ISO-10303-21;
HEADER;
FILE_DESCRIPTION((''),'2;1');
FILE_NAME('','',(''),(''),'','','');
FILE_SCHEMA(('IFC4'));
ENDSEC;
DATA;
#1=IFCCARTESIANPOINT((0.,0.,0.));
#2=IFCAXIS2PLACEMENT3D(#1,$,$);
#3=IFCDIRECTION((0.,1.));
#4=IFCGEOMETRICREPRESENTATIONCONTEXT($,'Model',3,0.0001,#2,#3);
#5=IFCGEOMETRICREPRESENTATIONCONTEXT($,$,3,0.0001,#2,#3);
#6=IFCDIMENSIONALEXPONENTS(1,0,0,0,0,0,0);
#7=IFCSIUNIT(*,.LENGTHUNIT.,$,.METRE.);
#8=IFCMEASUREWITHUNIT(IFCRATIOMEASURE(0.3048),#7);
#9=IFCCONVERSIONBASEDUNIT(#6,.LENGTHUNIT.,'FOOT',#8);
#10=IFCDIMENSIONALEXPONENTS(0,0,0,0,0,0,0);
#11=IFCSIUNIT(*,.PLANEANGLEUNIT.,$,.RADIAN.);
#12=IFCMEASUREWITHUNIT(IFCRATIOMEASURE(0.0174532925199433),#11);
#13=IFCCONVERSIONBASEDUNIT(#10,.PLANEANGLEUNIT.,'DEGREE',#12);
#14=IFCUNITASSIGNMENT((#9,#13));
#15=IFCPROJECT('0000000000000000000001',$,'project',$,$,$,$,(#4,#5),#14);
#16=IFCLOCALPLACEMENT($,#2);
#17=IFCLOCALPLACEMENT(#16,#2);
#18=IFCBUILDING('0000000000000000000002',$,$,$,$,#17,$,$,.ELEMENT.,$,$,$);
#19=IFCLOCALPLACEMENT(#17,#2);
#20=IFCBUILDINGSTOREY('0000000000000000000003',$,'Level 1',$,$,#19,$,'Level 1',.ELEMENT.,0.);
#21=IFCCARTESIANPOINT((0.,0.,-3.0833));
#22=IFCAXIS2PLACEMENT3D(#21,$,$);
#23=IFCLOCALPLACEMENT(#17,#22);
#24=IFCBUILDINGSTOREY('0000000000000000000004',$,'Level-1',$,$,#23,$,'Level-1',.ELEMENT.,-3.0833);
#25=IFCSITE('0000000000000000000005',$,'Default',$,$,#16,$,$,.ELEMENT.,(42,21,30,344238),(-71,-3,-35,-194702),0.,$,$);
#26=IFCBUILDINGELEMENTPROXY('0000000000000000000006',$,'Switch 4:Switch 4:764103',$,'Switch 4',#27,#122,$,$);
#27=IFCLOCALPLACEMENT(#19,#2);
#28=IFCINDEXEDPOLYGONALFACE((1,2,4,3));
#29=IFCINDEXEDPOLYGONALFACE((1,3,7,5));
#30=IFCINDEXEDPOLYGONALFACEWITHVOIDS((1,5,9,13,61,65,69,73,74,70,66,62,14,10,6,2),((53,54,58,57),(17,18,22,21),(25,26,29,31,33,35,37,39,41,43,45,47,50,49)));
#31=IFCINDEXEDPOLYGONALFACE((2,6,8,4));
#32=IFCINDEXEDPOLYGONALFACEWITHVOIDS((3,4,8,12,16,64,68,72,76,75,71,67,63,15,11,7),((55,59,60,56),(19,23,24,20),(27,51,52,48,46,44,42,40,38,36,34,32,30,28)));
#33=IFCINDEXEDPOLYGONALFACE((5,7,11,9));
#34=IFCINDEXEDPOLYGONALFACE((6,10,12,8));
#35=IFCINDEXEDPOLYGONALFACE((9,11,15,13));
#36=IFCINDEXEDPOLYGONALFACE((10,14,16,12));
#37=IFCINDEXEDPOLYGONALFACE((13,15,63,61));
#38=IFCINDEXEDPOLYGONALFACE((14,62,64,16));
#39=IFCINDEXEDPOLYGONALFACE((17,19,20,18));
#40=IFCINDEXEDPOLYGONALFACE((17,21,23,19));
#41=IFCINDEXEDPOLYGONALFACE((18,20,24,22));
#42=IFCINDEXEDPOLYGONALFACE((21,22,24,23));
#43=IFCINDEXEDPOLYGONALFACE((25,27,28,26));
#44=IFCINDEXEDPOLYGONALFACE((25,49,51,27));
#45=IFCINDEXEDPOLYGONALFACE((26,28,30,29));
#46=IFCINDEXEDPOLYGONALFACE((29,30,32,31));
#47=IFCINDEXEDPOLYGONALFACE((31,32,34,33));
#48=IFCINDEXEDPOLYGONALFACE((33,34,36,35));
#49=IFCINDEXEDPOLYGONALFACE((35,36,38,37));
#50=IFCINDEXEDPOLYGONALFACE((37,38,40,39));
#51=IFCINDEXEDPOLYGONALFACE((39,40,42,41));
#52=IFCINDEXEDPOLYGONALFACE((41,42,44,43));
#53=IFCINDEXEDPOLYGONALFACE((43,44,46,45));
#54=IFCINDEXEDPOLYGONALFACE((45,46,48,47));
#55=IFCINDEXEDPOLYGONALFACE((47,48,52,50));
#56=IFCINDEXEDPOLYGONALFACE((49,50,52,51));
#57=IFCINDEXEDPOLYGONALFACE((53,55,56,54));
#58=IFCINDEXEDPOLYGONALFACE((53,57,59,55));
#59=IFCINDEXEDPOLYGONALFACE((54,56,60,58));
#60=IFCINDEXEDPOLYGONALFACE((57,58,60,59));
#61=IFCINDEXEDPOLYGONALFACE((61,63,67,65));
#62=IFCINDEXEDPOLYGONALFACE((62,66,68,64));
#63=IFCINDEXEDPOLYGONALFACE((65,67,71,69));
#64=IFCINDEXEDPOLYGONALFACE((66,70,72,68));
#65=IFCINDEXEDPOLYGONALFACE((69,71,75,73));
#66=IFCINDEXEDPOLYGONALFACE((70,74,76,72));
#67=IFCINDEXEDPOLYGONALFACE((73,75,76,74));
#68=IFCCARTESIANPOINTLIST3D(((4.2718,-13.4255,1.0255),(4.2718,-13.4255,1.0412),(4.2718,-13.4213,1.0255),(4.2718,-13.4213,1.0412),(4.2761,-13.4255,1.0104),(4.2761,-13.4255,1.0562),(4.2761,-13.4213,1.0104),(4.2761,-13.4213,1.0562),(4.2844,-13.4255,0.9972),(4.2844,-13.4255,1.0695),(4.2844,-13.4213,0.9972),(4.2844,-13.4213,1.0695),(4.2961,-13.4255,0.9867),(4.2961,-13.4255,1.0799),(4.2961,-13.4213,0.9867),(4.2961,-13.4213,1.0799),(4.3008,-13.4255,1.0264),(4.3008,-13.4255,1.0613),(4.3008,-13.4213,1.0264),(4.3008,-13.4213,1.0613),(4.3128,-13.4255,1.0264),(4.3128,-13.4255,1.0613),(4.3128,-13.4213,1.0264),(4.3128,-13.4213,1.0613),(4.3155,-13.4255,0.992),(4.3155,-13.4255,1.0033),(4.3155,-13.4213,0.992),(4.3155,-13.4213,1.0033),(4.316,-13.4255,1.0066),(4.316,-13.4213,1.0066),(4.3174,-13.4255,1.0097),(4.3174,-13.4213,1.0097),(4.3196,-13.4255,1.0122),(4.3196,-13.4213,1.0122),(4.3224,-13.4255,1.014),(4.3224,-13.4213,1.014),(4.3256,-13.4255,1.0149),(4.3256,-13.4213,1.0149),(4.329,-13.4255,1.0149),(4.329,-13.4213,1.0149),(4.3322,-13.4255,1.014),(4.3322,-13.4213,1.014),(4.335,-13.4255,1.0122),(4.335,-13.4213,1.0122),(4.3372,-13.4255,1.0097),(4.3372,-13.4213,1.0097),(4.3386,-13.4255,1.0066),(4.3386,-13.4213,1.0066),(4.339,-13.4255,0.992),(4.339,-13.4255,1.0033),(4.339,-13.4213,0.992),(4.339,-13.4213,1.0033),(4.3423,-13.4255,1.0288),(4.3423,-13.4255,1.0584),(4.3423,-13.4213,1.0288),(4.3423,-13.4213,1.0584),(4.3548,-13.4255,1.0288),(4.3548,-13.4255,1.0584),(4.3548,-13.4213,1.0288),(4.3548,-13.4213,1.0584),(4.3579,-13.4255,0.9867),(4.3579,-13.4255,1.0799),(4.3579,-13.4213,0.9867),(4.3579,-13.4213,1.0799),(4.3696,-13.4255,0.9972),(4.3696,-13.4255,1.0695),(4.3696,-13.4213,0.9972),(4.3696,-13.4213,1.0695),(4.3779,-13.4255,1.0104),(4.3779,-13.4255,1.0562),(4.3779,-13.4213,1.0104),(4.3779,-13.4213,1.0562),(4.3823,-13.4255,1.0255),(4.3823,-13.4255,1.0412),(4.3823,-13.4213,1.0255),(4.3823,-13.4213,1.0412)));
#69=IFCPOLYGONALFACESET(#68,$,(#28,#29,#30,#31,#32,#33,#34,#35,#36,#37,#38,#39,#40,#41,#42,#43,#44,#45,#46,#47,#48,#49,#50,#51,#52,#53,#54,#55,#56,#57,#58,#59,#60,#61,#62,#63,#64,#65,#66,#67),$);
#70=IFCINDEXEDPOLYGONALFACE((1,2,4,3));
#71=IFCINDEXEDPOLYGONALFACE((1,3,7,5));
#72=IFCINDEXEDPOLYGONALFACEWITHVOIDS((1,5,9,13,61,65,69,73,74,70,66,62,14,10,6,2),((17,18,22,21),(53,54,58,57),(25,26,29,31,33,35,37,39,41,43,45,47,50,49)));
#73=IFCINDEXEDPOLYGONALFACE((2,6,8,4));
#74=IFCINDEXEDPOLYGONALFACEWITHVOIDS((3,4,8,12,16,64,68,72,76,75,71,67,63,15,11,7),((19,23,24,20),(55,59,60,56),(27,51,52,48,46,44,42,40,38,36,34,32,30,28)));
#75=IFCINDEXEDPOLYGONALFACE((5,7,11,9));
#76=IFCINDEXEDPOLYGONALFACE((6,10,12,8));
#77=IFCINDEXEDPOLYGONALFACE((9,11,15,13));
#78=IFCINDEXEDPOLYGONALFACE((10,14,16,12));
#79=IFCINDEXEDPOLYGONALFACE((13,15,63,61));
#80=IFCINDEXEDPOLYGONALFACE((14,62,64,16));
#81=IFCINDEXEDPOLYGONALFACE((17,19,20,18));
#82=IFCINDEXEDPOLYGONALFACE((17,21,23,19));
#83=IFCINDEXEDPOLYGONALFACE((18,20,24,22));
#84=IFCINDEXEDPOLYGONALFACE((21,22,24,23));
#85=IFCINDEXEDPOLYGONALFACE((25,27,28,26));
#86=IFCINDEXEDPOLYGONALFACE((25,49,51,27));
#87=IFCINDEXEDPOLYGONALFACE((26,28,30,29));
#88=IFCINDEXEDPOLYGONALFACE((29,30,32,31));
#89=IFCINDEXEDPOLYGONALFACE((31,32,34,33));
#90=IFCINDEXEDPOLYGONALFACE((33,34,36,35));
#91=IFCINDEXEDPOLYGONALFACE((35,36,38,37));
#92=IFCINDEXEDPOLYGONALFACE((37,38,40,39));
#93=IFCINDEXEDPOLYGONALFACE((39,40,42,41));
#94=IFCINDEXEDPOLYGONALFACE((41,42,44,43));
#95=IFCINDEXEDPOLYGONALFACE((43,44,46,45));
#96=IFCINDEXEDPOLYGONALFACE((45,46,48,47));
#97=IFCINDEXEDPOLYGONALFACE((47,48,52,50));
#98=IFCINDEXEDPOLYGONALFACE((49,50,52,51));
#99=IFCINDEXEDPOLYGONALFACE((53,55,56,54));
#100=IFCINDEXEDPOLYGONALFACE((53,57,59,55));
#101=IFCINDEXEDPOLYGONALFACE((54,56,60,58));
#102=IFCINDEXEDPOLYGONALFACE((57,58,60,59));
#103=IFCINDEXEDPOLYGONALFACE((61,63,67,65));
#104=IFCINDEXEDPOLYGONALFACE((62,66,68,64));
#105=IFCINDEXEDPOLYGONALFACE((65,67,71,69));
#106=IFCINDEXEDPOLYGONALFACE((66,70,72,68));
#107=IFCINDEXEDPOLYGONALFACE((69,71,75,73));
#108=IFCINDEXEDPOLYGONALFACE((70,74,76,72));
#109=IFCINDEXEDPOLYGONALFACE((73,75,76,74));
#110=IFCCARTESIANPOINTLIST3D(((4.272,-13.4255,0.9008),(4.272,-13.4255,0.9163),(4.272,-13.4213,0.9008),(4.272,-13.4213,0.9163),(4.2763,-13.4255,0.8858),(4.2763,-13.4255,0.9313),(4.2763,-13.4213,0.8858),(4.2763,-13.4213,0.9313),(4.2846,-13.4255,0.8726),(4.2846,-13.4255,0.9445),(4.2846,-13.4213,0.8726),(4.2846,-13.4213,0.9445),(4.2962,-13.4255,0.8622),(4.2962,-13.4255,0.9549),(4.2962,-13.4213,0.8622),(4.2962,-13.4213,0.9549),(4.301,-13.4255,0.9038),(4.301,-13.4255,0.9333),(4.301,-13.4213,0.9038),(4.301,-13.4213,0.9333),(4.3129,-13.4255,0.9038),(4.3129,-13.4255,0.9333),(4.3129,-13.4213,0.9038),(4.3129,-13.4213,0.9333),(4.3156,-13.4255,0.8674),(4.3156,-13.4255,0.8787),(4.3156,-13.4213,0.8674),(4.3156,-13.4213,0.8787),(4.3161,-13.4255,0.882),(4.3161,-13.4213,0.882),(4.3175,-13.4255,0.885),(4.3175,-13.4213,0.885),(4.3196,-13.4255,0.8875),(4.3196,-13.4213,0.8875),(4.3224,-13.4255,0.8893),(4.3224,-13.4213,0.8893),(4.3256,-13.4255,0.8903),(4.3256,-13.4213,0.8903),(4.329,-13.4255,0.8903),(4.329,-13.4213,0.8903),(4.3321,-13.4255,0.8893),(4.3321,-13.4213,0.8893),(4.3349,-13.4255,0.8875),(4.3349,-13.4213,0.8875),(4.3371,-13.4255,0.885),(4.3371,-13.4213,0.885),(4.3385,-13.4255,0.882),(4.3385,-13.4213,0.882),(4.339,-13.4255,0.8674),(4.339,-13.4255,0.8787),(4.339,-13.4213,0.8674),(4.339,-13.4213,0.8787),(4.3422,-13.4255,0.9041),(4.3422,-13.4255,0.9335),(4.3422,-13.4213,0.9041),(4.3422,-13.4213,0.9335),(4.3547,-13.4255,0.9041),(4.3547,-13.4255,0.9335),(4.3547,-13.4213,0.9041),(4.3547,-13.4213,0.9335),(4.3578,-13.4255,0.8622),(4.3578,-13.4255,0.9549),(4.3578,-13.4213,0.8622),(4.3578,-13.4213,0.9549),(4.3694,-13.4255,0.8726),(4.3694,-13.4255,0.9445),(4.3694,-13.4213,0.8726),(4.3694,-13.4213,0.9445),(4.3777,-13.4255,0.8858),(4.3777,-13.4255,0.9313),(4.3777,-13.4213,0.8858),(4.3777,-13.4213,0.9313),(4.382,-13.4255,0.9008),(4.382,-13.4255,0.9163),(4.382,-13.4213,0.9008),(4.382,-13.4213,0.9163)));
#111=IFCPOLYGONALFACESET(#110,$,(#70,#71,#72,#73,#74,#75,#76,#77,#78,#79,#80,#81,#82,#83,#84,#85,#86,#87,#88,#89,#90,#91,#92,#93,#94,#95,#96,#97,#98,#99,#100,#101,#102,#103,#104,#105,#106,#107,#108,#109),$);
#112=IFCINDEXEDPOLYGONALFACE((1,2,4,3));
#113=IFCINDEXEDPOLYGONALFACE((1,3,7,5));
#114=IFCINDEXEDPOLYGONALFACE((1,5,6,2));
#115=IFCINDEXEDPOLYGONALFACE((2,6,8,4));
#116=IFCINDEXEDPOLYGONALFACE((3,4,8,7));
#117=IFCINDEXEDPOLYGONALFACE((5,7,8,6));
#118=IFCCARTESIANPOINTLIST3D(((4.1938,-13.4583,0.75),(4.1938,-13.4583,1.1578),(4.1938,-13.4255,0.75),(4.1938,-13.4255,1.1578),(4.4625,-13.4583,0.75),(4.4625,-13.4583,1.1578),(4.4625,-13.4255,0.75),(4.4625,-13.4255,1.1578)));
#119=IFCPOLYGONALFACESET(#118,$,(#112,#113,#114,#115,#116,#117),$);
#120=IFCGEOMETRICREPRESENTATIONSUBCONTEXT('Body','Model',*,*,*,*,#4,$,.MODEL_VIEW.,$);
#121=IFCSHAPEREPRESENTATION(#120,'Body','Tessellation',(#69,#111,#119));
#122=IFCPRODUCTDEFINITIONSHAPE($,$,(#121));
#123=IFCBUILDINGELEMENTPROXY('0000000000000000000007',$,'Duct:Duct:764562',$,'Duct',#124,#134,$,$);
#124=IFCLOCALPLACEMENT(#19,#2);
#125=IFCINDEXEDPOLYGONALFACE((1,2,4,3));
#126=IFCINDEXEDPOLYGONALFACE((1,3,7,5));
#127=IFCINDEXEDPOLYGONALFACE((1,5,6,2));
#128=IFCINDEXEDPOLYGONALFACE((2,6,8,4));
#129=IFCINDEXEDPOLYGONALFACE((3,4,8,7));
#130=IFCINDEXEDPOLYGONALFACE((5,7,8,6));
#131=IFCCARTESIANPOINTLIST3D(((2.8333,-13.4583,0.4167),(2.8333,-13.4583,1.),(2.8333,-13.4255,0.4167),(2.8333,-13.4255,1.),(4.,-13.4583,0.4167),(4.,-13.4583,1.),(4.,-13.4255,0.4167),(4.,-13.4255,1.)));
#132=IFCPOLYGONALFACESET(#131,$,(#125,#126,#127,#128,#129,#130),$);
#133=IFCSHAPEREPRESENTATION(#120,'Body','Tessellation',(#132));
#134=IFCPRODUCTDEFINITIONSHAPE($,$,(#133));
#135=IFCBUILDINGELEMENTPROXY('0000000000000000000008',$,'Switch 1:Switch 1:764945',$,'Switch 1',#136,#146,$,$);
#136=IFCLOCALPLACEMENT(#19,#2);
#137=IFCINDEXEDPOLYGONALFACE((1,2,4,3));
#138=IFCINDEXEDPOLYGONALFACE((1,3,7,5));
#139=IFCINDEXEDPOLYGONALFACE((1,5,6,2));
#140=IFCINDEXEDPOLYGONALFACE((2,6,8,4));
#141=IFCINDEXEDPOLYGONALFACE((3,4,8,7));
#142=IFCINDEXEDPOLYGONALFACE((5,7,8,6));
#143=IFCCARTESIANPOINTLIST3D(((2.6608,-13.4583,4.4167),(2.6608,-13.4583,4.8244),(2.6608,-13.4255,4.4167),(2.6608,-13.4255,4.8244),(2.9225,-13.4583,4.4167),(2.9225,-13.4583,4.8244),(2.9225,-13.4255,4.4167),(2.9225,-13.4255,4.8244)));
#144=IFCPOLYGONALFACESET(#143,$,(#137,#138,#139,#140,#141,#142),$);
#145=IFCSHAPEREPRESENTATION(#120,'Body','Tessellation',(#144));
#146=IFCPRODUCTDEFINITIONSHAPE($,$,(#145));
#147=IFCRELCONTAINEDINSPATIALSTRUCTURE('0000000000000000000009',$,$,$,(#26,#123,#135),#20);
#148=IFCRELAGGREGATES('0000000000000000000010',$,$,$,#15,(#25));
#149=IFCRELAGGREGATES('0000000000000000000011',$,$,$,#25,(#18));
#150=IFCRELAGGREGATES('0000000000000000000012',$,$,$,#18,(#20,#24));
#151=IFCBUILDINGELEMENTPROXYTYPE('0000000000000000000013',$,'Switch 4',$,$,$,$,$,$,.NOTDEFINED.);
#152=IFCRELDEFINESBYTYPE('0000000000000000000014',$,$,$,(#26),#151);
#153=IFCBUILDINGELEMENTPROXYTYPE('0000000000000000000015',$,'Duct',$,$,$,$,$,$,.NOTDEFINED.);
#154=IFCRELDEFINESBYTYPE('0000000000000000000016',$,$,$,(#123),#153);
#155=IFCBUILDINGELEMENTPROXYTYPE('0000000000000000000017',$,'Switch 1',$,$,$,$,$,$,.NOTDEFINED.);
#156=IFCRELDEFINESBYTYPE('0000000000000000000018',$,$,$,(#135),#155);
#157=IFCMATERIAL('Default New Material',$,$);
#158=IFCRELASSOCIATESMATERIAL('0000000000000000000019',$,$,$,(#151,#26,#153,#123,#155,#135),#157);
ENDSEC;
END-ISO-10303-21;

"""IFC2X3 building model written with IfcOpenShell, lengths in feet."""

from ifc_helpers import new_model, entity, si_unit, converted_unit, direction, frame, frame_2d, origin, origin_2d_with_axis, place, context, subcontext, project, spatial, polyline, circle_curve, parameter, trimmed, segment, composite_curve, rectangle, outline, extrude, source, transform, mapped, material, type_object, type_shapes, element, save


model = new_model("IFC2X3")

# Units and contexts
model_context = context("Model", 3, precision=0.0001, world=origin(), true_north=direction((0.0, 1.0)))
context_of_model = context(None, 3, precision=0.0001, world=origin(), true_north=direction((0.0, 1.0)))
body_context = subcontext(model_context, "Body", "Model", "MODEL_VIEW")
ifc_project = project(units=[converted_unit("LENGTHUNIT", "FOOT", entity("IfcRatioMeasure", 0.3048), si_unit("LENGTHUNIT", "METRE"), dimensions=[1, 0, 0, 0, 0, 0, 0]), converted_unit("PLANEANGLEUNIT", "DEGREE", entity("IfcRatioMeasure", 0.0174532925199433), si_unit("PLANEANGLEUNIT", "RADIAN"), dimensions=[0, 0, 0, 0, 0, 0, 0])], contexts=[model_context, context_of_model])

# Site, building, storey
site_placement = place(None, origin())
site = spatial("IfcSite", under=ifc_project, at=site_placement, Name="Default", CompositionType="ELEMENT", RefLatitude=(42, 21, 30, 344238), RefLongitude=(-71, -3, -35, -194702), RefElevation=0.0)
building_placement = place(site_placement, origin())
building = spatial("IfcBuilding", under=site, at=building_placement, CompositionType="ELEMENT")
storey_1_placement = place(building_placement, origin())
storey_1 = spatial("IfcBuildingStorey", under=building, at=storey_1_placement, Name="Level 1", LongName="Level 1", CompositionType="ELEMENT", Elevation=0.0)

# Shared definitions
ifc_material_1 = material(Name="Default New Material")

# Shared definitions
storey_2_placement = place(building_placement, frame((0.0, 0.0, -3.0833)))
storey_2 = spatial("IfcBuildingStorey", under=building, at=storey_2_placement, Name="Level-1", LongName="Level-1", CompositionType="ELEMENT", Elevation=-3.0833)

# Building element proxies
building_element_proxy_type_1 = type_object("IfcBuildingElementProxyType", Name="Switch 4", PredefinedType="NOTDEFINED", material=ifc_material_1)
shared_shape_1 = source(origin(), body_context, "Body", "SweptSolid", [
    extrude(outline(composite_curve([segment(polyline([(-0.0309, -0.0466), (0.0309, -0.0466)]), True, "CONTINUOUS"), segment(trimmed(circle_curve(frame_2d((-0.0003, 0.0), x_axis=(-1.0, 0.0)), 0.0561), [parameter(123.794741)], [parameter(236.205259)], True, "PARAMETER"), True, "CONTINUOUS"), segment(polyline([(0.0309, 0.0466), (-0.0309, 0.0466)]), True, "CONTINUOUS"), segment(trimmed(circle_curve(frame_2d((0.0003, 0.0), x_axis=(1.0, 0.0)), 0.0561), [parameter(123.794741)], [parameter(236.205259)], True, "PARAMETER"), True, "CONTINUOUS")], self_intersect=False), holes=[polyline([(0.0142, 0.0279), (0.0262, 0.0279), (0.0262, -0.0069), (0.0142, -0.0069), (0.0142, 0.0279)]), polyline([(-0.0153, 0.025), (-0.0153, -0.0045), (-0.0278, -0.0045), (-0.0278, 0.025), (-0.0153, 0.025)]), composite_curve([segment(polyline([(-0.012, -0.0413), (-0.012, -0.03)]), True, "CONTINUOUS"), segment(trimmed(circle_curve(frame_2d((-0.0003, -0.03), x_axis=(-1.0, 0.0)), 0.0117), [parameter(180.0)], [parameter(0.0)], True, "PARAMETER"), False, "CONTINUOUS"), segment(polyline([(0.0115, -0.03), (0.0115, -0.0413)]), True, "CONTINUOUS"), segment(polyline([(0.0115, -0.0413), (-0.012, -0.0413)]), True, "CONTINUOUS")], self_intersect=False)]), frame((-0.0011, 0.0328, 0.2833), z_axis=(0.0, 1.0, 0.0), x_axis=(-1.0, 0.0, 0.0)), (0.0, 0.0, 1.0), 0.0042),
    extrude(outline(composite_curve([segment(polyline([(-0.0308, -0.0464), (0.0308, -0.0464)]), True, "CONTINUOUS"), segment(trimmed(circle_curve(frame_2d((-0.0003, 0.0), x_axis=(-1.0, 0.0)), 0.0558), [parameter(123.794741)], [parameter(236.205259)], True, "PARAMETER"), True, "CONTINUOUS"), segment(polyline([(0.0308, 0.0464), (-0.0308, 0.0464)]), True, "CONTINUOUS"), segment(trimmed(circle_curve(frame_2d((0.0003, 0.0), x_axis=(1.0, 0.0)), 0.0558), [parameter(123.794741)], [parameter(236.205259)], True, "PARAMETER"), True, "CONTINUOUS")], self_intersect=False), holes=[polyline([(0.0141, 0.0247), (0.026, 0.0247), (0.026, -0.0047), (0.0141, -0.0047), (0.0141, 0.0247)]), polyline([(-0.0152, 0.0249), (-0.0152, -0.0045), (-0.0277, -0.0045), (-0.0277, 0.0249), (-0.0152, 0.0249)]), composite_curve([segment(polyline([(-0.012, -0.0411), (-0.012, -0.0299)]), True, "CONTINUOUS"), segment(trimmed(circle_curve(frame_2d((-0.0003, -0.0299), x_axis=(-1.0, 0.0)), 0.0117), [parameter(180.0)], [parameter(0.0)], True, "PARAMETER"), False, "CONTINUOUS"), segment(polyline([(0.0114, -0.0299), (0.0114, -0.0411)]), True, "CONTINUOUS"), segment(polyline([(0.0114, -0.0411), (-0.012, -0.0411)]), True, "CONTINUOUS")], self_intersect=False)]), frame((-0.0011, 0.0328, 0.1586), z_axis=(0.0, 1.0, 0.0), x_axis=(-1.0, 0.0, 0.0)), (0.0, 0.0, 1.0), 0.0042),
    extrude(rectangle(XDim=0.0328, YDim=0.2687, at=origin_2d_with_axis()), frame((0.0, 0.0164, 0.0), z_axis=(0.0, 0.0, 1.0), x_axis=(0.0, -1.0, 0.0)), (0.0, 0.0, 1.0), 0.4078),
])
type_shapes(building_element_proxy_type_1, [shared_shape_1])
proxy_1_placement = place(storey_1_placement, frame((4.3281, -13.4583, 0.75)))
element("IfcBuildingElementProxy", 1, at=proxy_1_placement, inside=storey_1, type_object=building_element_proxy_type_1, material=ifc_material_1, Name="Switch 4:Switch 4:764103", ObjectType="Switch 4", context=body_context, shape_type="MappedRepresentation", body=[
    mapped(shared_shape_1, transform((0.0, 0.0, 0.0), scale=1.0)),
])
building_element_proxy_type_2 = type_object("IfcBuildingElementProxyType", Name="Duct", PredefinedType="NOTDEFINED", material=ifc_material_1)
shared_shape_2 = source(origin(), body_context, "Body", "SweptSolid", [
    extrude(rectangle(XDim=0.0329, YDim=1.1667, at=origin_2d_with_axis()), frame((0.4525, -0.0164, 0.0), z_axis=(0.0, 0.0, 1.0), x_axis=(0.0, 1.0, 0.0)), (0.0, 0.0, 1.0), 0.5833),
])
type_shapes(building_element_proxy_type_2, [shared_shape_2])
proxy_2_placement = place(storey_1_placement, frame((3.8691, -13.4583, 0.4167), z_axis=(0.0, 0.0, 1.0), x_axis=(-1.0, 0.0, 0.0)))
element("IfcBuildingElementProxy", 2, at=proxy_2_placement, inside=storey_1, type_object=building_element_proxy_type_2, material=ifc_material_1, Name="Duct:Duct:764562", ObjectType="Duct", context=body_context, shape_type="MappedRepresentation", body=[
    mapped(shared_shape_2, transform((0.0, 0.0, 0.0), scale=1.0)),
])
building_element_proxy_type_3 = type_object("IfcBuildingElementProxyType", Name="Switch 1", PredefinedType="NOTDEFINED", material=ifc_material_1)
shared_shape_3 = source(origin(), body_context, "Body", "SweptSolid", [
    extrude(rectangle(XDim=0.0328, YDim=0.2617, at=origin_2d_with_axis()), frame((0.0, -0.0164, 0.0), z_axis=(0.0, 0.0, 1.0), x_axis=(0.0, 1.0, 0.0)), (0.0, 0.0, 1.0), 0.4078),
])
type_shapes(building_element_proxy_type_3, [shared_shape_3])
proxy_3_placement = place(storey_1_placement, frame((2.7917, -13.4583, 4.4167), z_axis=(0.0, 0.0, 1.0), x_axis=(-1.0, 0.0, 0.0)))
element("IfcBuildingElementProxy", 3, at=proxy_3_placement, inside=storey_1, type_object=building_element_proxy_type_3, material=ifc_material_1, Name="Switch 1:Switch 1:764945", ObjectType="Switch 1", context=body_context, shape_type="MappedRepresentation", body=[
    mapped(shared_shape_3, transform((0.0, 0.0, 0.0), scale=1.0)),
])

save(model, "model.ifc")
